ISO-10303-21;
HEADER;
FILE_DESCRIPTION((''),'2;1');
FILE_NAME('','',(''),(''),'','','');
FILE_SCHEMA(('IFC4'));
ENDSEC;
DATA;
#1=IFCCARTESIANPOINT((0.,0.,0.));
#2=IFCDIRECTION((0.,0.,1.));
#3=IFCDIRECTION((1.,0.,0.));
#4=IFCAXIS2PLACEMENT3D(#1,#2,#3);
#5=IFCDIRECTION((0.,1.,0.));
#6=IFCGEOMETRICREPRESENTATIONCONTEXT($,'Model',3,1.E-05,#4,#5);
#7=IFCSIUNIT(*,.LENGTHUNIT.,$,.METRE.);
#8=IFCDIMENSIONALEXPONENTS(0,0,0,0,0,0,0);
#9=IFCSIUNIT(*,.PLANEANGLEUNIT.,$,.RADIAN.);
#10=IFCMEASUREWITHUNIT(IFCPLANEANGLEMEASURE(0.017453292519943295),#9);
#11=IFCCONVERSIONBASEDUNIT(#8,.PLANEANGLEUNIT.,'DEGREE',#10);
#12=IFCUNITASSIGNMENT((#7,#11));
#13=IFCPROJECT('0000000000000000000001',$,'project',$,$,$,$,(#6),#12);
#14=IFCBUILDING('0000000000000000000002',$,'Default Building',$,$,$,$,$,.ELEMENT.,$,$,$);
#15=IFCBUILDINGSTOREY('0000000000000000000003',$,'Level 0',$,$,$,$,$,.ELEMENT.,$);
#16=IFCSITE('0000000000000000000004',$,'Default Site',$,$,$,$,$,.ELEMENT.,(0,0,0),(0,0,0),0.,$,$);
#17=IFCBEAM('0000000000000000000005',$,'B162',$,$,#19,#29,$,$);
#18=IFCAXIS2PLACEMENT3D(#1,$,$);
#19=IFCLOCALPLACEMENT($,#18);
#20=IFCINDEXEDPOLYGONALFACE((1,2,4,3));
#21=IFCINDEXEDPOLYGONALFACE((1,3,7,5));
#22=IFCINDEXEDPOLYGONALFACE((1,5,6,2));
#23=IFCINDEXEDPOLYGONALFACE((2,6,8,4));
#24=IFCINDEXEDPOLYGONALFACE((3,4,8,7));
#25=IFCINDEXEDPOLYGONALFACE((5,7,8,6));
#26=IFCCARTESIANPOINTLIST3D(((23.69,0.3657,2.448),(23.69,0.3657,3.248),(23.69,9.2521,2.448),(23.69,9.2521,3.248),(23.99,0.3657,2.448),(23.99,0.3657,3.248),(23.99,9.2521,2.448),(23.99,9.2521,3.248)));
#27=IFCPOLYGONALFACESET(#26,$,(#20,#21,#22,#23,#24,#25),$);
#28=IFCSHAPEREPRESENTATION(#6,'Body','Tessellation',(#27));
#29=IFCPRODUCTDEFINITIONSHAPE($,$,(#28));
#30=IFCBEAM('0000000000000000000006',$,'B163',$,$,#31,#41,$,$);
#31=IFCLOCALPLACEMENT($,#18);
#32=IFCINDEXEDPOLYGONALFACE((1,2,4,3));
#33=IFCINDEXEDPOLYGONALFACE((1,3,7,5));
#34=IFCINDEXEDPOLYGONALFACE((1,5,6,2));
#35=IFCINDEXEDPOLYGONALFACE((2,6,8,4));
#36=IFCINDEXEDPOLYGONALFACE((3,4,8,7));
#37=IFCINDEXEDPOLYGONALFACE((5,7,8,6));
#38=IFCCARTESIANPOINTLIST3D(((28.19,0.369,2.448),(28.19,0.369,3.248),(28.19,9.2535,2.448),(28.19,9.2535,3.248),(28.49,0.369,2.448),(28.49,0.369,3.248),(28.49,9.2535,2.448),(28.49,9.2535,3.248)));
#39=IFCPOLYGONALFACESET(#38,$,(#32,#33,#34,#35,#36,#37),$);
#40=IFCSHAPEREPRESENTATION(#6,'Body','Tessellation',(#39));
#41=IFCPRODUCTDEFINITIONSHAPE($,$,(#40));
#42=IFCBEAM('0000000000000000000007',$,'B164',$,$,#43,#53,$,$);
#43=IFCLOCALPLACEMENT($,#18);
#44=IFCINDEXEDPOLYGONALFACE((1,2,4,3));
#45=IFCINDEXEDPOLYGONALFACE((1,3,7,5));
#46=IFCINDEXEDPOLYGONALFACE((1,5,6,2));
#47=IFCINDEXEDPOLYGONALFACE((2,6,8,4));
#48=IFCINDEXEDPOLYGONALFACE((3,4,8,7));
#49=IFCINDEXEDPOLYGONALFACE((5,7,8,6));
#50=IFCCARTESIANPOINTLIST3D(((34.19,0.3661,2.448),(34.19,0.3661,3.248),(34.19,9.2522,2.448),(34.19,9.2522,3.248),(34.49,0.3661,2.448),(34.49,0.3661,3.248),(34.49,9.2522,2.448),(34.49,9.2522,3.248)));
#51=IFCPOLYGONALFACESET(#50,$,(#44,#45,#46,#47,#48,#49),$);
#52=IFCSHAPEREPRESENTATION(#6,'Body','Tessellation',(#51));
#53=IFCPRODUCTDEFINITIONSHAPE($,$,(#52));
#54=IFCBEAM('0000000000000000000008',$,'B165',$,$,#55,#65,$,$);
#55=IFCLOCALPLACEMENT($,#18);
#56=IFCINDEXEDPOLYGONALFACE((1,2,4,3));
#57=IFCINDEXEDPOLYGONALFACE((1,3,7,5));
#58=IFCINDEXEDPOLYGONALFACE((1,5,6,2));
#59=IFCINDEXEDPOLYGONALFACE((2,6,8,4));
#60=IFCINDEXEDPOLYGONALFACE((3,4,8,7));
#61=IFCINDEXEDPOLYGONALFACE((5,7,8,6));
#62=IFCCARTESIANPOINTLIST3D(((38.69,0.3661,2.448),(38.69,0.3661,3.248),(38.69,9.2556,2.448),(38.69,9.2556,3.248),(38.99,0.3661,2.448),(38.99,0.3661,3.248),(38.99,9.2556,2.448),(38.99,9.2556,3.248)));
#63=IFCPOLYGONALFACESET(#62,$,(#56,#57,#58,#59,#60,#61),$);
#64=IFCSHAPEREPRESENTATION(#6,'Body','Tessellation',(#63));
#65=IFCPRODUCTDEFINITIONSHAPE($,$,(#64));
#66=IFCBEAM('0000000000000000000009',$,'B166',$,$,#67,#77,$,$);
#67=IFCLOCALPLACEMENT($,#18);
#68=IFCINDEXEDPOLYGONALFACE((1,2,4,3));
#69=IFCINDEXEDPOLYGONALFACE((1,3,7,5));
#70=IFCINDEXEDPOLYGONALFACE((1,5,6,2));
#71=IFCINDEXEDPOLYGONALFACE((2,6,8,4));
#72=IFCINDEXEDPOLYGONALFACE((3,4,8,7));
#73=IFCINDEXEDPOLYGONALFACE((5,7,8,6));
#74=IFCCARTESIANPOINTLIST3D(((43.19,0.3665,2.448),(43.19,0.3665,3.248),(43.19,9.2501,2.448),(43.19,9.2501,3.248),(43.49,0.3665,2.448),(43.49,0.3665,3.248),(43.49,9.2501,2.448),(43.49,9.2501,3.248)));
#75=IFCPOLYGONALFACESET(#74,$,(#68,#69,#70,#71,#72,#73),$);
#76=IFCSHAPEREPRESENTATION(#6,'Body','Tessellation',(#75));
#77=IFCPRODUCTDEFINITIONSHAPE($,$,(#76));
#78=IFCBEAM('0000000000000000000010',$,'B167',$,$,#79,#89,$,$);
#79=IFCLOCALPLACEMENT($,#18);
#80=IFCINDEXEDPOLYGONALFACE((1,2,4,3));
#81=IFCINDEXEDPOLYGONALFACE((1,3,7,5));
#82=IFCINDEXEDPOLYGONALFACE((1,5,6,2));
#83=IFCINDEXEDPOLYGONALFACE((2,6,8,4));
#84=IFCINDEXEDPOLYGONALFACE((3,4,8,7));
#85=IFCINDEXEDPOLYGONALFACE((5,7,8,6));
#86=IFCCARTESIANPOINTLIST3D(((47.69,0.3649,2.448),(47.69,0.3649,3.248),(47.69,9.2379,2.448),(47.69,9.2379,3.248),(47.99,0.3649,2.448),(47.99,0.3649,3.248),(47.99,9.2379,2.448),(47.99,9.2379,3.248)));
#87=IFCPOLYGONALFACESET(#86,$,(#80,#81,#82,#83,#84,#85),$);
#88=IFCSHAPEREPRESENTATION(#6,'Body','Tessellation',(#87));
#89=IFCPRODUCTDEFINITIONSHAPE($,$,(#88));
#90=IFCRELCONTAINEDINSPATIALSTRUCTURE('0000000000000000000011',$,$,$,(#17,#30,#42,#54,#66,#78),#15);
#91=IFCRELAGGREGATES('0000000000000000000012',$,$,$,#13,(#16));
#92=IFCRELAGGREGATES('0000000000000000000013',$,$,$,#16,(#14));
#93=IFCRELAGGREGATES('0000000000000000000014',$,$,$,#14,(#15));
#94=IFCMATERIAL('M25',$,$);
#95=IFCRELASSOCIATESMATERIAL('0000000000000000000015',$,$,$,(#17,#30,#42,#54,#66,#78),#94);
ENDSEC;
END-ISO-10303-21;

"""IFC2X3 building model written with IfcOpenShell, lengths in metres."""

from ifc_helpers import new_model, entity, si_unit, converted_unit, direction, frame, frame_2d, origin_with_axes, place, context, project, spatial, rectangle, extrude, material, element, save


model = new_model("IFC2X3")

# Units and contexts
model_context = context("Model", 3, precision=1e-05, world=origin_with_axes(), true_north=direction((0.0, 1.0, 0.0)))
ifc_project = project(units=[si_unit("LENGTHUNIT", "METRE"), converted_unit("PLANEANGLEUNIT", "DEGREE", entity("IfcPlaneAngleMeasure", 0.017453292519943295), si_unit("PLANEANGLEUNIT", "RADIAN"), dimensions=[0, 0, 0, 0, 0, 0, 0])], contexts=[model_context])

# Site, building, storey
site = spatial("IfcSite", under=ifc_project, Name="Default Site", CompositionType="ELEMENT", RefLatitude=(0, 0, 0), RefLongitude=(0, 0, 0), RefElevation=0.0)
building = spatial("IfcBuilding", under=site, Name="Default Building", CompositionType="ELEMENT")
storey = spatial("IfcBuildingStorey", under=building, Name="Level 0", CompositionType="ELEMENT")

# Beams
ifc_material = material(Name="M25")
placement = place(None, origin_with_axes())
element("IfcBeam", 1, at=placement, inside=storey, material=ifc_material, Name="B162", context=model_context, shape_type="SweptSolid", body=[
    extrude(rectangle(XDim=0.3, YDim=0.8, at=frame_2d((0.0, 0.0), x_axis=(0.0, 1.0, 0.0))), frame((23.84, 0.3657, 2.848), z_axis=(0.0, 1.0, 0.0), x_axis=(0.0, 0.0, -1.0)), (0.0, 0.0, 1.0), 8.8864),
])
element("IfcBeam", 2, at=placement, inside=storey, material=ifc_material, Name="B163", context=model_context, shape_type="SweptSolid", body=[
    extrude(rectangle(XDim=0.3, YDim=0.8, at=frame_2d((0.0, 0.0), x_axis=(0.0, 1.0, 0.0))), frame((28.34, 0.369, 2.848), z_axis=(0.0, 1.0, 0.0), x_axis=(0.0, 0.0, -1.0)), (0.0, 0.0, 1.0), 8.8845),
])
element("IfcBeam", 3, at=placement, inside=storey, material=ifc_material, Name="B164", context=model_context, shape_type="SweptSolid", body=[
    extrude(rectangle(XDim=0.3, YDim=0.8, at=frame_2d((0.0, 0.0), x_axis=(0.0, 1.0, 0.0))), frame((34.34, 0.3661, 2.848), z_axis=(0.0, 1.0, 0.0), x_axis=(0.0, 0.0, -1.0)), (0.0, 0.0, 1.0), 8.8861),
])
element("IfcBeam", 4, at=placement, inside=storey, material=ifc_material, Name="B165", context=model_context, shape_type="SweptSolid", body=[
    extrude(rectangle(XDim=0.3, YDim=0.8, at=frame_2d((0.0, 0.0), x_axis=(0.0, 1.0, 0.0))), frame((38.84, 0.3661, 2.848), z_axis=(0.0, 1.0, 0.0), x_axis=(0.0, 0.0, -1.0)), (0.0, 0.0, 1.0), 8.8895),
])
element("IfcBeam", 5, at=placement, inside=storey, material=ifc_material, Name="B166", context=model_context, shape_type="SweptSolid", body=[
    extrude(rectangle(XDim=0.3, YDim=0.8, at=frame_2d((0.0, 0.0), x_axis=(0.0, 1.0, 0.0))), frame((43.34, 0.3665, 2.848), z_axis=(0.0, 1.0, 0.0), x_axis=(0.0, 0.0, -1.0)), (0.0, 0.0, 1.0), 8.8836),
])
element("IfcBeam", 6, at=placement, inside=storey, material=ifc_material, Name="B167", context=model_context, shape_type="SweptSolid", body=[
    extrude(rectangle(XDim=0.3, YDim=0.8, at=frame_2d((0.0, 0.0), x_axis=(0.0, 1.0, 0.0))), frame((47.84, 0.3649, 2.848), z_axis=(0.0, 1.0, 0.0), x_axis=(0.0, 0.0, -1.0)), (0.0, 0.0, 1.0), 8.873),
])

save(model, "model.ifc")
